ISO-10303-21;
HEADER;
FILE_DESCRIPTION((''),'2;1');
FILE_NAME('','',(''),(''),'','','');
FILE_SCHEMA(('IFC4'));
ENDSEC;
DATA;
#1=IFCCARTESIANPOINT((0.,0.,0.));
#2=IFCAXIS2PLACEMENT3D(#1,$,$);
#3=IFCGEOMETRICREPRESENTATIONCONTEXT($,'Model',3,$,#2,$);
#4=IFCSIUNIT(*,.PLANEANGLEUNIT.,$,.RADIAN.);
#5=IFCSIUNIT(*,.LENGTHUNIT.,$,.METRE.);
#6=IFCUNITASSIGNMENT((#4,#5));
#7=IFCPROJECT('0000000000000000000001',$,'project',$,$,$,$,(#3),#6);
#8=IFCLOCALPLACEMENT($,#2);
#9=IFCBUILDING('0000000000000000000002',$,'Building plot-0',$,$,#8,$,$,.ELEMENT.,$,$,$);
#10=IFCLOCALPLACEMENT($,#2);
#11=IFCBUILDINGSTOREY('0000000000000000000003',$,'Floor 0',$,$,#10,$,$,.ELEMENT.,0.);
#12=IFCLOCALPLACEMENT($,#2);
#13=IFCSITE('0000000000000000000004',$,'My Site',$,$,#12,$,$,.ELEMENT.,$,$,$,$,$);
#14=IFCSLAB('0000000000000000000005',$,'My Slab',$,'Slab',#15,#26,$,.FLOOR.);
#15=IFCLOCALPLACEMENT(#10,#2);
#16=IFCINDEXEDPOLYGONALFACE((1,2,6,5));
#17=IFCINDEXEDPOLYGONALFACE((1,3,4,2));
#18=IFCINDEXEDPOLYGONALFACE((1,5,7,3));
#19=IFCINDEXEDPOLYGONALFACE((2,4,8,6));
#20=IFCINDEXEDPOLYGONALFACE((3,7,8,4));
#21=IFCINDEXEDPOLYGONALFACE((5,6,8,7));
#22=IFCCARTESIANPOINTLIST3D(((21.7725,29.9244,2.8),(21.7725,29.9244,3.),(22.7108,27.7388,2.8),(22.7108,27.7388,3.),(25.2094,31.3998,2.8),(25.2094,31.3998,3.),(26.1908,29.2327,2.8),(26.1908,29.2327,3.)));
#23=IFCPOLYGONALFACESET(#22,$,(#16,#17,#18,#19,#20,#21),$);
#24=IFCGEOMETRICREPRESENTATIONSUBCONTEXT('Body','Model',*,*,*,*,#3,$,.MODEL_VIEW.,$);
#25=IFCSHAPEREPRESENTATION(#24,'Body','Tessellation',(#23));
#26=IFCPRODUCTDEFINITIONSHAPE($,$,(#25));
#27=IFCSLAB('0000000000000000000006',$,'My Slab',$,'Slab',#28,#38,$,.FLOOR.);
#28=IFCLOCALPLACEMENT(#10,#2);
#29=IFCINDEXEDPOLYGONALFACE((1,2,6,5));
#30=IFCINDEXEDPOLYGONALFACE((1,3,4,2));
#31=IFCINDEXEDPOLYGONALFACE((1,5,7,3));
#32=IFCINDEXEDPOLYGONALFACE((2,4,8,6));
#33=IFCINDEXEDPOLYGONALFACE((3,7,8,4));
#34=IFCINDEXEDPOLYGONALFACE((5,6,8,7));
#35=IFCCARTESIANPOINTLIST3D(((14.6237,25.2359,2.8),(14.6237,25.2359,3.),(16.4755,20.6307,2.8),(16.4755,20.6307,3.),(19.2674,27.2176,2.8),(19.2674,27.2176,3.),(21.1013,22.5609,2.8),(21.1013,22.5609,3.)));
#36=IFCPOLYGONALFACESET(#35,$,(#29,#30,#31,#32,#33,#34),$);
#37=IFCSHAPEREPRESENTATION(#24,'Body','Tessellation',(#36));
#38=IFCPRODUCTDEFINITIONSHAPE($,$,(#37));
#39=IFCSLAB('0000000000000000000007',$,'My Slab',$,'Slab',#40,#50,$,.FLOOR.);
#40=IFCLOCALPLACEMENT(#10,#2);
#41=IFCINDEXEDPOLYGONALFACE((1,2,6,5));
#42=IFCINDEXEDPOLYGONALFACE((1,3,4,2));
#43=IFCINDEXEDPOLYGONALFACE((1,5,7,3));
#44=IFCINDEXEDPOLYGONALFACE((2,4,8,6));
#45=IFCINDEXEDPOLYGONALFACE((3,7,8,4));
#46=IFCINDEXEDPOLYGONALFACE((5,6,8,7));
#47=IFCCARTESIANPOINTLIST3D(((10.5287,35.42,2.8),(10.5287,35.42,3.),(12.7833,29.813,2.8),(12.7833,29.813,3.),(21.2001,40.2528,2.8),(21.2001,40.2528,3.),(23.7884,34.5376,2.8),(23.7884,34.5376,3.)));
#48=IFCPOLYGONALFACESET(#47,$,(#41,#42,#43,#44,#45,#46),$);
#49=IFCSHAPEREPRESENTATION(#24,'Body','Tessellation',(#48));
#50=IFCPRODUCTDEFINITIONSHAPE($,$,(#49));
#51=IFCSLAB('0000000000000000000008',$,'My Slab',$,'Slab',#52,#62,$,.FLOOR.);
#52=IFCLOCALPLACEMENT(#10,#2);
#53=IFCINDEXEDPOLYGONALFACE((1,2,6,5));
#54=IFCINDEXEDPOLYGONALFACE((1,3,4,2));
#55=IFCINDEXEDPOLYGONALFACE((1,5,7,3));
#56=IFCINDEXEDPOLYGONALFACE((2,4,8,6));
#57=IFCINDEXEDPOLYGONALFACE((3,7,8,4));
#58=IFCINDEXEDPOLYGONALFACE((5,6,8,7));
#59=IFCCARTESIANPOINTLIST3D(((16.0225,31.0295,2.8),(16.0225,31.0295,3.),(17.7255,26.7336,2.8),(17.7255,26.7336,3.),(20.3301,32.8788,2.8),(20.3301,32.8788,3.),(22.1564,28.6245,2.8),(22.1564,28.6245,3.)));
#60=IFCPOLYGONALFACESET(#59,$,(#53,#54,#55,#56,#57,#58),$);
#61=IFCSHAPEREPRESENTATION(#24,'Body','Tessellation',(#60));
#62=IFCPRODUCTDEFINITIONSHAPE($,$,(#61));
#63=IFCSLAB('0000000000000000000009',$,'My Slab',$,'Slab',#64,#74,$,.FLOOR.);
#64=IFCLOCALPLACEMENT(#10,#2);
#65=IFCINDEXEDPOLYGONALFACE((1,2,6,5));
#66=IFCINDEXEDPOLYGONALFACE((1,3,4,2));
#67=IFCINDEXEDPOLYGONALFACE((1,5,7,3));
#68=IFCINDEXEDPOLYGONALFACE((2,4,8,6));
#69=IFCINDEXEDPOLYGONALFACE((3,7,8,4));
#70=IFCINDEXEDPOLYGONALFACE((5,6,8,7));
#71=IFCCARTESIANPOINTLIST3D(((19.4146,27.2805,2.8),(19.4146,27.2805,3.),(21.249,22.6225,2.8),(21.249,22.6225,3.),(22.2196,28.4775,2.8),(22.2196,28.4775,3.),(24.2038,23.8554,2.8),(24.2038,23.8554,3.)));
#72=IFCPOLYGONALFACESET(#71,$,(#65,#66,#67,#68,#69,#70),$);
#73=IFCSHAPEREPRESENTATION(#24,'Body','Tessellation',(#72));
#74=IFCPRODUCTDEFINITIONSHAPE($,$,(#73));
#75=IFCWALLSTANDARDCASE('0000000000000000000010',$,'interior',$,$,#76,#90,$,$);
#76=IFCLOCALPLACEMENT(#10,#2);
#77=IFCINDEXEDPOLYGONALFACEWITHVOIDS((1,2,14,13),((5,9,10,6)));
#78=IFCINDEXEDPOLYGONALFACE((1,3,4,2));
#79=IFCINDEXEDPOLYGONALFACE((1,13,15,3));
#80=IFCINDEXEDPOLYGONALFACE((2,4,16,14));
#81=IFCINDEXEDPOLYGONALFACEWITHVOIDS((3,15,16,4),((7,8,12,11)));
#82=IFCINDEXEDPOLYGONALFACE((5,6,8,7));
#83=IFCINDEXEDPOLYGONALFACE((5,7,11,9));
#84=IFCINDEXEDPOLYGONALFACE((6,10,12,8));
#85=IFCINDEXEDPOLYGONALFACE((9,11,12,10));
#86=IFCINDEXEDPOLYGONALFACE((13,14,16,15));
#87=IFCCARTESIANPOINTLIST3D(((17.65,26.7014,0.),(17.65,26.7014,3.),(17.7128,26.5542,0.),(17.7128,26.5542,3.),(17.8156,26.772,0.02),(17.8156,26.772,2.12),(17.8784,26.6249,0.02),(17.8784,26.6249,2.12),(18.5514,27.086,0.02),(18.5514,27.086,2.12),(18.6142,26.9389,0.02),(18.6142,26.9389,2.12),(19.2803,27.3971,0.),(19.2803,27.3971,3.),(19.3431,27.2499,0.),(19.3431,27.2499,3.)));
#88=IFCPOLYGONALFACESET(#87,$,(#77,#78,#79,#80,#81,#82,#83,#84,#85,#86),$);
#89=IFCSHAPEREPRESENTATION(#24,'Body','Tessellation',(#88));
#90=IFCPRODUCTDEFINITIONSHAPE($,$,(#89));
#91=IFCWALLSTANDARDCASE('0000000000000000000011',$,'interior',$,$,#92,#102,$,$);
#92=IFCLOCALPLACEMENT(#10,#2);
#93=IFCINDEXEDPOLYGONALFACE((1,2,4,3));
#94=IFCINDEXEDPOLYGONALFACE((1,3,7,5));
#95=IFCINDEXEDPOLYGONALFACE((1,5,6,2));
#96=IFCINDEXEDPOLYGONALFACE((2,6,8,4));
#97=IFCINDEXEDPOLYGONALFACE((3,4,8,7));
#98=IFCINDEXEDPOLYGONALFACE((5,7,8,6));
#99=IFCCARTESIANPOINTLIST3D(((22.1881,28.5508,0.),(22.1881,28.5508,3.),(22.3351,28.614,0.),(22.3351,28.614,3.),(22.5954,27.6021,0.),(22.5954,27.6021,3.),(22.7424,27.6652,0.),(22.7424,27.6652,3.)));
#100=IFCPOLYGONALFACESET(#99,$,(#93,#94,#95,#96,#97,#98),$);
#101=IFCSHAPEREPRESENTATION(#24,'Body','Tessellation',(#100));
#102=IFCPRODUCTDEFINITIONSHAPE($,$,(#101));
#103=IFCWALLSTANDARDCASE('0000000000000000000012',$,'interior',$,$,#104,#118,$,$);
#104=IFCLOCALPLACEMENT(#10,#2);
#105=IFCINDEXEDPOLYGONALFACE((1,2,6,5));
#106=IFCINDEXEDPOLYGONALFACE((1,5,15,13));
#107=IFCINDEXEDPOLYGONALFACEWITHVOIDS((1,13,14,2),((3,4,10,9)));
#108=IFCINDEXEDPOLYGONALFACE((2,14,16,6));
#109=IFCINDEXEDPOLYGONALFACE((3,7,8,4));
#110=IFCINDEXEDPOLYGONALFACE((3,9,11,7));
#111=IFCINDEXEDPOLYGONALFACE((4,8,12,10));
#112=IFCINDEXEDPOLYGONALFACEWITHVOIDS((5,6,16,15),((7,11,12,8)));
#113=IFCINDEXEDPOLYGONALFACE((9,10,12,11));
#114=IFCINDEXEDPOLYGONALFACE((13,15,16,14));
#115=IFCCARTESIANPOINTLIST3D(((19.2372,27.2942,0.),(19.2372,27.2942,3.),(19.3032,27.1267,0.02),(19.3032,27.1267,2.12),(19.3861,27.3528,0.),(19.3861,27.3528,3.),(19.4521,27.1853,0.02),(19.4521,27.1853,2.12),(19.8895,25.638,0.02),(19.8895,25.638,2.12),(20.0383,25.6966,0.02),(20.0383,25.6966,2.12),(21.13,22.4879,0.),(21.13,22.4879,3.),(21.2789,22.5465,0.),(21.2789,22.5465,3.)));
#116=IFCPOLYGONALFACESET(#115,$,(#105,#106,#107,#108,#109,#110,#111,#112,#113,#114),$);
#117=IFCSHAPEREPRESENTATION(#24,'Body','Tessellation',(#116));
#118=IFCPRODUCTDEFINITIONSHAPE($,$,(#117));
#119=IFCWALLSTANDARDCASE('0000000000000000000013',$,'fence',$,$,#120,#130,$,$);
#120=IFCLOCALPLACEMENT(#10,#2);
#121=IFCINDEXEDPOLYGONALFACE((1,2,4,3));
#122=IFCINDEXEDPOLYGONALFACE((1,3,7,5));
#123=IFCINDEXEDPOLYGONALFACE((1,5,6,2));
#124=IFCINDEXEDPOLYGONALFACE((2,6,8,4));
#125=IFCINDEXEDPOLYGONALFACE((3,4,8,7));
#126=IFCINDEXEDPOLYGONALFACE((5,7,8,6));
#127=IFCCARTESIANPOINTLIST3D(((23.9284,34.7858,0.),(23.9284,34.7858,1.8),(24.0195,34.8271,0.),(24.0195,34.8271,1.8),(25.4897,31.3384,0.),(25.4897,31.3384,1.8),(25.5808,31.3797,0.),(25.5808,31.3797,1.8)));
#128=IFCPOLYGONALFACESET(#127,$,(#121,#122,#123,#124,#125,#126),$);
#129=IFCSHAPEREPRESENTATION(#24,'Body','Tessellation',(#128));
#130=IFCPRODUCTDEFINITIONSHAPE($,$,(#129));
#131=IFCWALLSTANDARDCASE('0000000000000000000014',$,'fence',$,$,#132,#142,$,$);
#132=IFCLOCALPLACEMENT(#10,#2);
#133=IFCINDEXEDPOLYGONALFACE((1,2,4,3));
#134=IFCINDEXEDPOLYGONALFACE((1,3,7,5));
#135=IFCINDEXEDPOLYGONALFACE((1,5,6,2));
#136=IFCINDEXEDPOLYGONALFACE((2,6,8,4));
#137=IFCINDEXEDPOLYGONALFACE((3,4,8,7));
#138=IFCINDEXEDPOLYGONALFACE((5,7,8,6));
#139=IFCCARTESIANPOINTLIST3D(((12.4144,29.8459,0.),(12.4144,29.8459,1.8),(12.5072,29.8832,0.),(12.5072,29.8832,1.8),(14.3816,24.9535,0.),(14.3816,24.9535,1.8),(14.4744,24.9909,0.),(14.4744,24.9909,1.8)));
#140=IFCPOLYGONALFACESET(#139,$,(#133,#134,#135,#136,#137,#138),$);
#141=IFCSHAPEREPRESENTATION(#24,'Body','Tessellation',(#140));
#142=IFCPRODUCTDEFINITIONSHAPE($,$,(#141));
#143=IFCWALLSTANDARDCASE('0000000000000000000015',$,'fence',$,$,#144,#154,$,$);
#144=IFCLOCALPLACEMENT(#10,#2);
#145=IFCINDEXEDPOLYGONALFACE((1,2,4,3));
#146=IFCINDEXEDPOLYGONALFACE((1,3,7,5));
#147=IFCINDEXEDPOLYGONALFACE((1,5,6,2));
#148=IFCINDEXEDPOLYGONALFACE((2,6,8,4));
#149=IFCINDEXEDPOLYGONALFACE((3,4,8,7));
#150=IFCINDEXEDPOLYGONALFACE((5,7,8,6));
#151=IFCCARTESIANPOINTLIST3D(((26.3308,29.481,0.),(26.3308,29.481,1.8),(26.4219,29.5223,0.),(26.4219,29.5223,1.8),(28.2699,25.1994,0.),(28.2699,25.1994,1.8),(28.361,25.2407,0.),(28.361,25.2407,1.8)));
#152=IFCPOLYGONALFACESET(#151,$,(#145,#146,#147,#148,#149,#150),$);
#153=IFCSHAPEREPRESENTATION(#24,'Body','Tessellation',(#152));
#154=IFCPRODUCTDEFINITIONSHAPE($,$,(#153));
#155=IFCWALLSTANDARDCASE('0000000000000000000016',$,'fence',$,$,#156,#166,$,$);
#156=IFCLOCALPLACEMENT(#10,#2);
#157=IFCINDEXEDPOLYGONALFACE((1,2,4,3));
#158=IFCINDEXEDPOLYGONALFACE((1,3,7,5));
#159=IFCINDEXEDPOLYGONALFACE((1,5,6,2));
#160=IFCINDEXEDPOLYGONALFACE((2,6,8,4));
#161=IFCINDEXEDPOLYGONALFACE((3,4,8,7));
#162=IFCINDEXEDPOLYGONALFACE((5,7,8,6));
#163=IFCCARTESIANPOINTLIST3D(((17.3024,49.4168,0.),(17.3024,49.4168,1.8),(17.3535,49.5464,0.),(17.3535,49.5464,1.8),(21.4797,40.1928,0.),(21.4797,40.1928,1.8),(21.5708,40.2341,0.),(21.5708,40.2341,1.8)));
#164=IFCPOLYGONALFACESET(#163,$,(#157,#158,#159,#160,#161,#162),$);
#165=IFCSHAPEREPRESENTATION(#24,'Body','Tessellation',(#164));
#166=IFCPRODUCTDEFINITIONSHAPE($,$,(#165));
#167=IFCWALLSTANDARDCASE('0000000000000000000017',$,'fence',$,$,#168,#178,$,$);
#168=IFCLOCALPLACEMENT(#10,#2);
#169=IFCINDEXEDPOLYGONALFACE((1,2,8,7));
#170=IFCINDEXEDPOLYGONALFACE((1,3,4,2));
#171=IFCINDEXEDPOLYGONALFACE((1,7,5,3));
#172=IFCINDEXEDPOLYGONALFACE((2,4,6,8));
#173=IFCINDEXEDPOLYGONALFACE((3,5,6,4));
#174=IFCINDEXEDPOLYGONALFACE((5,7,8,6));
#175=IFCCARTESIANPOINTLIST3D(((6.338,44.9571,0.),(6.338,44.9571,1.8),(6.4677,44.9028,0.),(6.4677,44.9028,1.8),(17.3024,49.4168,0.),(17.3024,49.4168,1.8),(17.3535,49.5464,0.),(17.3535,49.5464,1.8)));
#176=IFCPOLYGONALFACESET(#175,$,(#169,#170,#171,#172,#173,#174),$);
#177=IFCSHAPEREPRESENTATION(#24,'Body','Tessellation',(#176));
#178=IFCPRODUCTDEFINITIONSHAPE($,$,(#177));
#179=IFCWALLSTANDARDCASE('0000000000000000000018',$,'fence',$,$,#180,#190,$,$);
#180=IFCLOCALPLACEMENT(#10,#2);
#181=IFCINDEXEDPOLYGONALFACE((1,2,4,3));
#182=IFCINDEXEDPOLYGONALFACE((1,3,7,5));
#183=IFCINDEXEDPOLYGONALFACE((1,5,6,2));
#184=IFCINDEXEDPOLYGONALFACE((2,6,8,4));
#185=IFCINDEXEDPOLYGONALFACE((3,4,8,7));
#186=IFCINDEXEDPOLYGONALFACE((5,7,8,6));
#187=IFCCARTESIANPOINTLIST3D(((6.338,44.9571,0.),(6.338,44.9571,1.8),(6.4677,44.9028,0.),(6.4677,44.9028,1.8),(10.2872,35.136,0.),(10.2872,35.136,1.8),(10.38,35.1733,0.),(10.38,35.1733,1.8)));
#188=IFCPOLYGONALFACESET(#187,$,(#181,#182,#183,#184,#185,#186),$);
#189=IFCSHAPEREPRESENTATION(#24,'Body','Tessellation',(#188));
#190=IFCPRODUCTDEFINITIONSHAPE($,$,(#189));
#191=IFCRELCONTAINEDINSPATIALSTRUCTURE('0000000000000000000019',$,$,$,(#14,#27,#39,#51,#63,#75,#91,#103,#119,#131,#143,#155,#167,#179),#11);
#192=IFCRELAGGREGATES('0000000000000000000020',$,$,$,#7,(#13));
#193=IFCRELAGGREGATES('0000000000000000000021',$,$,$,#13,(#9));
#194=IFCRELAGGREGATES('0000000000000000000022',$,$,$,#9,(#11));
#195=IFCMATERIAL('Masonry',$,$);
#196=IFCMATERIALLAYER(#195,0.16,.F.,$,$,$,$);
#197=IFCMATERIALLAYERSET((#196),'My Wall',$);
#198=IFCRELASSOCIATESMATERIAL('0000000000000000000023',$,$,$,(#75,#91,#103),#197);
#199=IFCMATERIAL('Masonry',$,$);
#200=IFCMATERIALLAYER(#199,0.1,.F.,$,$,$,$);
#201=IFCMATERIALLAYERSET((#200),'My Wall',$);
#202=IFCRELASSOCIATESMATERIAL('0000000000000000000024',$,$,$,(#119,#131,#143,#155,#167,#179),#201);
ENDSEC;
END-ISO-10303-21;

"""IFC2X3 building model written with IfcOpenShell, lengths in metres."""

from ifc_helpers import new_model, si_unit, frame, origin, place, context, subcontext, project, spatial, polyline, outline, extrude, material, layer, layer_set, layer_usage, element, save


model = new_model("IFC2X3")

# Units and contexts
model_context = context("Model", 3, world=origin())
body_context = subcontext(model_context, "Body", "Model", "MODEL_VIEW")
ifc_project = project(units=[si_unit("PLANEANGLEUNIT", "RADIAN"), si_unit("LENGTHUNIT", "METRE")], contexts=[model_context])

# Site, building, storey
site_placement = place(None, origin())
site = spatial("IfcSite", under=ifc_project, at=site_placement, Name="My Site", CompositionType="ELEMENT")
building_placement = place(None, origin())
building = spatial("IfcBuilding", under=site, at=building_placement, Name="Building plot-0", CompositionType="ELEMENT")
storey_placement = place(None, origin())
storey = spatial("IfcBuildingStorey", under=building, at=storey_placement, Name="Floor 0", CompositionType="ELEMENT", Elevation=0.0)

# Slabs
slab_1_placement = place(storey_placement, frame((0.0, 0.0, 2.8)))
element("IfcSlab", 1, at=slab_1_placement, inside=storey, Name="My Slab", ObjectType="Slab", PredefinedType="FLOOR", context=body_context, shape_type="SweptSolid", body=[
    extrude(outline(polyline([(21.7725, 29.9244), (22.7108, 27.7388), (26.1908, 29.2327), (25.2094, 31.3998), (21.7725, 29.9244)])), origin(), (0.0, 0.0, 1.0), 0.2),
])
slab_2_placement = place(storey_placement, frame((0.0, 0.0, 2.8)))
element("IfcSlab", 2, at=slab_2_placement, inside=storey, Name="My Slab", ObjectType="Slab", PredefinedType="FLOOR", context=body_context, shape_type="SweptSolid", body=[
    extrude(outline(polyline([(19.2674, 27.2176), (14.6237, 25.2359), (16.4755, 20.6307), (21.1013, 22.5609), (19.2674, 27.2176)])), origin(), (0.0, 0.0, 1.0), 0.2),
])
slab_3_placement = place(storey_placement, frame((0.0, 0.0, 2.8)))
element("IfcSlab", 3, at=slab_3_placement, inside=storey, Name="My Slab", ObjectType="Slab", PredefinedType="FLOOR", context=body_context, shape_type="SweptSolid", body=[
    extrude(outline(polyline([(10.5287, 35.42), (12.7833, 29.813), (23.7884, 34.5376), (21.2001, 40.2528), (10.5287, 35.42)])), origin(), (0.0, 0.0, 1.0), 0.2),
])
slab_4_placement = place(storey_placement, frame((0.0, 0.0, 2.8)))
element("IfcSlab", 4, at=slab_4_placement, inside=storey, Name="My Slab", ObjectType="Slab", PredefinedType="FLOOR", context=body_context, shape_type="SweptSolid", body=[
    extrude(outline(polyline([(16.0225, 31.0295), (17.7255, 26.7336), (22.1564, 28.6245), (20.3301, 32.8788), (16.0225, 31.0295)])), origin(), (0.0, 0.0, 1.0), 0.2),
])
slab_5_placement = place(storey_placement, frame((0.0, 0.0, 2.8)))
element("IfcSlab", 5, at=slab_5_placement, inside=storey, Name="My Slab", ObjectType="Slab", PredefinedType="FLOOR", context=body_context, shape_type="SweptSolid", body=[
    extrude(outline(polyline([(22.2196, 28.4775), (19.4146, 27.2805), (21.249, 22.6225), (24.2038, 23.8554), (22.2196, 28.4775)])), origin(), (0.0, 0.0, 1.0), 0.2),
])

# Wall, opening
ifc_material_1 = material(Name="Masonry")
ifc_layer_1 = layer(ifc_material_1, 0.16, ventilated=False)
ifc_layer_set_1 = layer_set([ifc_layer_1], Name="My Wall")
ifc_layer_usage_1 = layer_usage(ifc_layer_set_1, "AXIS2", "NEGATIVE", 0.08)
wall_1_placement = place(storey_placement, origin())
wall_1 = element("IfcWallStandardCase", 6, at=wall_1_placement, inside=storey, material=ifc_layer_usage_1, Name="interior", context=body_context, shape_type="SweptSolid", body=[
    extrude(outline(polyline([(19.3431, 27.2499), (19.2803, 27.3971), (17.65, 26.7014), (17.7128, 26.5542), (19.3431, 27.2499)])), origin(), (0.0, 0.0, 1.0), 3.0),
])
opening_1_placement = place(storey_placement, frame((0.0, 0.0, 0.02)))
element("IfcOpeningElement", 7, at=opening_1_placement, cuts=wall_1, ObjectType="Opening", context=body_context, shape_type="SweptSolid", body=[
    extrude(outline(polyline([(18.5514, 27.086), (17.8156, 26.772), (17.8784, 26.6249), (18.6142, 26.9389), (18.5514, 27.086)])), origin(), (0.0, 0.0, 1.0), 2.1),
])

# Wall
wall_2_placement = place(storey_placement, origin())
element("IfcWallStandardCase", 8, at=wall_2_placement, inside=storey, material=ifc_layer_usage_1, Name="interior", context=body_context, shape_type="SweptSolid", body=[
    extrude(outline(polyline([(22.3351, 28.614), (22.1881, 28.5508), (22.5954, 27.6021), (22.7424, 27.6652), (22.3351, 28.614)])), origin(), (0.0, 0.0, 1.0), 3.0),
])

# Wall, opening
wall_3_placement = place(storey_placement, origin())
wall_3 = element("IfcWallStandardCase", 9, at=wall_3_placement, inside=storey, material=ifc_layer_usage_1, Name="interior", context=body_context, shape_type="SweptSolid", body=[
    extrude(outline(polyline([(19.3861, 27.3528), (19.2372, 27.2942), (21.13, 22.4879), (21.2789, 22.5465), (19.3861, 27.3528)])), origin(), (0.0, 0.0, 1.0), 3.0),
])
opening_2_placement = place(storey_placement, frame((0.0, 0.0, 0.02)))
element("IfcOpeningElement", 10, at=opening_2_placement, cuts=wall_3, ObjectType="Opening", context=body_context, shape_type="SweptSolid", body=[
    extrude(outline(polyline([(19.3032, 27.1267), (19.8895, 25.638), (20.0383, 25.6966), (19.4521, 27.1853), (19.3032, 27.1267)])), origin(), (0.0, 0.0, 1.0), 2.1),
])

# Walls
ifc_material_2 = material(Name="Masonry")
ifc_layer_2 = layer(ifc_material_2, 0.1, ventilated=False)
ifc_layer_set_2 = layer_set([ifc_layer_2], Name="My Wall")
ifc_layer_usage_2 = layer_usage(ifc_layer_set_2, "AXIS2", "NEGATIVE", -0.15)
wall_4_placement = place(storey_placement, origin())
element("IfcWallStandardCase", 11, at=wall_4_placement, inside=storey, material=ifc_layer_usage_2, Name="fence", context=body_context, shape_type="SweptSolid", body=[
    extrude(outline(polyline([(25.4897, 31.3384), (25.5808, 31.3797), (24.0195, 34.8271), (23.9284, 34.7858), (25.4897, 31.3384)])), origin(), (0.0, 0.0, 1.0), 1.8),
])
wall_5_placement = place(storey_placement, origin())
element("IfcWallStandardCase", 12, at=wall_5_placement, inside=storey, material=ifc_layer_usage_2, Name="fence", context=body_context, shape_type="SweptSolid", body=[
    extrude(outline(polyline([(12.5072, 29.8832), (12.4144, 29.8459), (14.3816, 24.9535), (14.4744, 24.9909), (12.5072, 29.8832)])), origin(), (0.0, 0.0, 1.0), 1.8),
])
wall_6_placement = place(storey_placement, origin())
element("IfcWallStandardCase", 13, at=wall_6_placement, inside=storey, material=ifc_layer_usage_2, Name="fence", context=body_context, shape_type="SweptSolid", body=[
    extrude(outline(polyline([(28.2699, 25.1994), (28.361, 25.2407), (26.4219, 29.5223), (26.3308, 29.481), (28.2699, 25.1994)])), origin(), (0.0, 0.0, 1.0), 1.8),
])
wall_7_placement = place(storey_placement, origin())
element("IfcWallStandardCase", 14, at=wall_7_placement, inside=storey, material=ifc_layer_usage_2, Name="fence", context=body_context, shape_type="SweptSolid", body=[
    extrude(outline(polyline([(21.4797, 40.1928), (21.5708, 40.2341), (17.3535, 49.5464), (17.3024, 49.4168), (21.4797, 40.1928)])), origin(), (0.0, 0.0, 1.0), 1.8),
])
wall_8_placement = place(storey_placement, origin())
element("IfcWallStandardCase", 15, at=wall_8_placement, inside=storey, material=ifc_layer_usage_2, Name="fence", context=body_context, shape_type="SweptSolid", body=[
    extrude(outline(polyline([(17.3024, 49.4168), (17.3535, 49.5464), (6.338, 44.9571), (6.4677, 44.9028), (17.3024, 49.4168)])), origin(), (0.0, 0.0, 1.0), 1.8),
])
wall_9_placement = place(storey_placement, origin())
element("IfcWallStandardCase", 16, at=wall_9_placement, inside=storey, material=ifc_layer_usage_2, Name="fence", context=body_context, shape_type="SweptSolid", body=[
    extrude(outline(polyline([(6.4677, 44.9028), (6.338, 44.9571), (10.2872, 35.136), (10.38, 35.1733), (6.4677, 44.9028)])), origin(), (0.0, 0.0, 1.0), 1.8),
])

save(model, "model.ifc")
